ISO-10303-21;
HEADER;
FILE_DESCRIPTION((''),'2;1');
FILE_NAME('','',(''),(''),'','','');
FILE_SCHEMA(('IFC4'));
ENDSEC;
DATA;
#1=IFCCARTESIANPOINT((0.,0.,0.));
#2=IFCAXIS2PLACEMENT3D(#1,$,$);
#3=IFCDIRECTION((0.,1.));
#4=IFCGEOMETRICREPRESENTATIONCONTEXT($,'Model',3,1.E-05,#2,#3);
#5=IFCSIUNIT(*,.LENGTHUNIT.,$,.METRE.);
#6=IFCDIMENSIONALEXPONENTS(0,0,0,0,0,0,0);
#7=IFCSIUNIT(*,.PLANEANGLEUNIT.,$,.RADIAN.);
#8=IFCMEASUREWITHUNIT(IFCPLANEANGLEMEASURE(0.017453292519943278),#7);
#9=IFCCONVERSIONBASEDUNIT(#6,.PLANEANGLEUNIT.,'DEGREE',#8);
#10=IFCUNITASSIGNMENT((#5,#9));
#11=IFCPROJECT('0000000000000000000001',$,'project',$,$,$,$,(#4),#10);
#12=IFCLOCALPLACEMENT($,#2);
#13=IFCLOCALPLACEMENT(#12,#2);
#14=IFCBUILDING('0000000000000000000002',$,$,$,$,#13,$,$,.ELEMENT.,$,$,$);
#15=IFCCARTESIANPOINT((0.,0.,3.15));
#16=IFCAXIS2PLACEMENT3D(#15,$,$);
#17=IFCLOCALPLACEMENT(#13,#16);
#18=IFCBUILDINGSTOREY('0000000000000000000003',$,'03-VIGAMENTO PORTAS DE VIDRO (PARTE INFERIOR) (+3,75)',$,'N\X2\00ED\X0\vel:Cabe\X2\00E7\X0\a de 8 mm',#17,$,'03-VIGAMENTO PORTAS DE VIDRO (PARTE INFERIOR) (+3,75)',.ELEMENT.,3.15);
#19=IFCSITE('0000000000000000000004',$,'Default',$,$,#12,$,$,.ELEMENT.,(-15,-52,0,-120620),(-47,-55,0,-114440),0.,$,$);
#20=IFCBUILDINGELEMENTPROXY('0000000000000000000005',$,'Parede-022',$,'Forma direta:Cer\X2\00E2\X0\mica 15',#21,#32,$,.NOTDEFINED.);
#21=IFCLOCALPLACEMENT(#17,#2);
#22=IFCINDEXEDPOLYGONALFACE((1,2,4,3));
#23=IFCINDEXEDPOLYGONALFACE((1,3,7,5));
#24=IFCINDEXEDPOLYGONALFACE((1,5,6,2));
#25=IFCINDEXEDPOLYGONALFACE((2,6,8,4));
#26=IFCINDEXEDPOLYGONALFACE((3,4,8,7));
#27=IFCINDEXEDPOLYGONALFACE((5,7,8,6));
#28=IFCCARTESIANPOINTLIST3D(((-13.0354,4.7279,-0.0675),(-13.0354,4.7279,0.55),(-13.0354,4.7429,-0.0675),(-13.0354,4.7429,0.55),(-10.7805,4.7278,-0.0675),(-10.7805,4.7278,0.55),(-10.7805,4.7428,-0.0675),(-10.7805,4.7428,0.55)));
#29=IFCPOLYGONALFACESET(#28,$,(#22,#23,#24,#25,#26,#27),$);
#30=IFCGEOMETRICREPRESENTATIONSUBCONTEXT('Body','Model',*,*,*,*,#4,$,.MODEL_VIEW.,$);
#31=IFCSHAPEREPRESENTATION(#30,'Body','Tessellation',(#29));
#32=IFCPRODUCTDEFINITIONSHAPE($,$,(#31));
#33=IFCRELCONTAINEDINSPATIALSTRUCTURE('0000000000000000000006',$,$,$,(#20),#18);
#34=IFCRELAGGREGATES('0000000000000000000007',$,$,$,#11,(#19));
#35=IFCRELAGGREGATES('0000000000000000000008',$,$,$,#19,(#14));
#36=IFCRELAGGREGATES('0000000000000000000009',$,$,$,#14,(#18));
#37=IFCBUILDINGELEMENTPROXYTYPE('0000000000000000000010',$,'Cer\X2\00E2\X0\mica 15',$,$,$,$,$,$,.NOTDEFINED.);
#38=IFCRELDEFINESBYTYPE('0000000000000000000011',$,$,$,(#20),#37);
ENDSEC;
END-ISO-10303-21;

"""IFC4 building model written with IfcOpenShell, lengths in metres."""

from ifc_helpers import new_model, entity, si_unit, converted_unit, direction, frame, origin, place, context, subcontext, project, spatial, indexed_curve, outline, extrude, type_object, element, save


model = new_model("IFC4")

# Units and contexts
model_context = context("Model", 3, precision=1e-05, world=origin(), true_north=direction((0.0, 1.0)))
body_context = subcontext(model_context, "Body", "Model", "MODEL_VIEW")
ifc_project = project(units=[si_unit("LENGTHUNIT", "METRE"), converted_unit("PLANEANGLEUNIT", "DEGREE", entity("IfcPlaneAngleMeasure", 0.017453292519943278), si_unit("PLANEANGLEUNIT", "RADIAN"), dimensions=[0, 0, 0, 0, 0, 0, 0])], contexts=[model_context])

# Site, building, storey
site_placement = place(None, origin())
site = spatial("IfcSite", under=ifc_project, at=site_placement, Name="Default", CompositionType="ELEMENT", RefLatitude=(-15, -52, 0, -120620), RefLongitude=(-47, -55, 0, -114440), RefElevation=0.0)
building_placement = place(site_placement, origin())
building = spatial("IfcBuilding", under=site, at=building_placement, CompositionType="ELEMENT")
storey_placement = place(building_placement, frame((0.0, 0.0, 3.15)))
storey = spatial("IfcBuildingStorey", under=building, at=storey_placement, Name="03-VIGAMENTO PORTAS DE VIDRO (PARTE INFERIOR) (+3,75)", ObjectType="Nível:Cabeça de 8 mm", LongName="03-VIGAMENTO PORTAS DE VIDRO (PARTE INFERIOR) (+3,75)", CompositionType="ELEMENT", Elevation=3.15)

# Building element proxy
building_element_proxy_type = type_object("IfcBuildingElementProxyType", Name="Cerâmica 15", PredefinedType="NOTDEFINED")
proxy_placement = place(storey_placement, origin())
element("IfcBuildingElementProxy", 1, at=proxy_placement, inside=storey, type_object=building_element_proxy_type, Name="Parede-022", ObjectType="Forma direta:Cerâmica 15", PredefinedType="NOTDEFINED", context=body_context, shape_type="SweptSolid", body=[
    extrude(outline(indexed_curve([(-0.0075, -1.1274), (0.0075, -1.1274), (0.0075, 1.1274), (-0.0075, 1.1274), (-0.0075, -1.1274)], self_intersect=False)), frame((-11.908, 4.7354, -0.0675), z_axis=(0.0, 0.0, 1.0), x_axis=(0.000013, 1.0, 0.0)), (0.0, 0.0, 1.0), 0.6175),
])

save(model, "model.ifc")
